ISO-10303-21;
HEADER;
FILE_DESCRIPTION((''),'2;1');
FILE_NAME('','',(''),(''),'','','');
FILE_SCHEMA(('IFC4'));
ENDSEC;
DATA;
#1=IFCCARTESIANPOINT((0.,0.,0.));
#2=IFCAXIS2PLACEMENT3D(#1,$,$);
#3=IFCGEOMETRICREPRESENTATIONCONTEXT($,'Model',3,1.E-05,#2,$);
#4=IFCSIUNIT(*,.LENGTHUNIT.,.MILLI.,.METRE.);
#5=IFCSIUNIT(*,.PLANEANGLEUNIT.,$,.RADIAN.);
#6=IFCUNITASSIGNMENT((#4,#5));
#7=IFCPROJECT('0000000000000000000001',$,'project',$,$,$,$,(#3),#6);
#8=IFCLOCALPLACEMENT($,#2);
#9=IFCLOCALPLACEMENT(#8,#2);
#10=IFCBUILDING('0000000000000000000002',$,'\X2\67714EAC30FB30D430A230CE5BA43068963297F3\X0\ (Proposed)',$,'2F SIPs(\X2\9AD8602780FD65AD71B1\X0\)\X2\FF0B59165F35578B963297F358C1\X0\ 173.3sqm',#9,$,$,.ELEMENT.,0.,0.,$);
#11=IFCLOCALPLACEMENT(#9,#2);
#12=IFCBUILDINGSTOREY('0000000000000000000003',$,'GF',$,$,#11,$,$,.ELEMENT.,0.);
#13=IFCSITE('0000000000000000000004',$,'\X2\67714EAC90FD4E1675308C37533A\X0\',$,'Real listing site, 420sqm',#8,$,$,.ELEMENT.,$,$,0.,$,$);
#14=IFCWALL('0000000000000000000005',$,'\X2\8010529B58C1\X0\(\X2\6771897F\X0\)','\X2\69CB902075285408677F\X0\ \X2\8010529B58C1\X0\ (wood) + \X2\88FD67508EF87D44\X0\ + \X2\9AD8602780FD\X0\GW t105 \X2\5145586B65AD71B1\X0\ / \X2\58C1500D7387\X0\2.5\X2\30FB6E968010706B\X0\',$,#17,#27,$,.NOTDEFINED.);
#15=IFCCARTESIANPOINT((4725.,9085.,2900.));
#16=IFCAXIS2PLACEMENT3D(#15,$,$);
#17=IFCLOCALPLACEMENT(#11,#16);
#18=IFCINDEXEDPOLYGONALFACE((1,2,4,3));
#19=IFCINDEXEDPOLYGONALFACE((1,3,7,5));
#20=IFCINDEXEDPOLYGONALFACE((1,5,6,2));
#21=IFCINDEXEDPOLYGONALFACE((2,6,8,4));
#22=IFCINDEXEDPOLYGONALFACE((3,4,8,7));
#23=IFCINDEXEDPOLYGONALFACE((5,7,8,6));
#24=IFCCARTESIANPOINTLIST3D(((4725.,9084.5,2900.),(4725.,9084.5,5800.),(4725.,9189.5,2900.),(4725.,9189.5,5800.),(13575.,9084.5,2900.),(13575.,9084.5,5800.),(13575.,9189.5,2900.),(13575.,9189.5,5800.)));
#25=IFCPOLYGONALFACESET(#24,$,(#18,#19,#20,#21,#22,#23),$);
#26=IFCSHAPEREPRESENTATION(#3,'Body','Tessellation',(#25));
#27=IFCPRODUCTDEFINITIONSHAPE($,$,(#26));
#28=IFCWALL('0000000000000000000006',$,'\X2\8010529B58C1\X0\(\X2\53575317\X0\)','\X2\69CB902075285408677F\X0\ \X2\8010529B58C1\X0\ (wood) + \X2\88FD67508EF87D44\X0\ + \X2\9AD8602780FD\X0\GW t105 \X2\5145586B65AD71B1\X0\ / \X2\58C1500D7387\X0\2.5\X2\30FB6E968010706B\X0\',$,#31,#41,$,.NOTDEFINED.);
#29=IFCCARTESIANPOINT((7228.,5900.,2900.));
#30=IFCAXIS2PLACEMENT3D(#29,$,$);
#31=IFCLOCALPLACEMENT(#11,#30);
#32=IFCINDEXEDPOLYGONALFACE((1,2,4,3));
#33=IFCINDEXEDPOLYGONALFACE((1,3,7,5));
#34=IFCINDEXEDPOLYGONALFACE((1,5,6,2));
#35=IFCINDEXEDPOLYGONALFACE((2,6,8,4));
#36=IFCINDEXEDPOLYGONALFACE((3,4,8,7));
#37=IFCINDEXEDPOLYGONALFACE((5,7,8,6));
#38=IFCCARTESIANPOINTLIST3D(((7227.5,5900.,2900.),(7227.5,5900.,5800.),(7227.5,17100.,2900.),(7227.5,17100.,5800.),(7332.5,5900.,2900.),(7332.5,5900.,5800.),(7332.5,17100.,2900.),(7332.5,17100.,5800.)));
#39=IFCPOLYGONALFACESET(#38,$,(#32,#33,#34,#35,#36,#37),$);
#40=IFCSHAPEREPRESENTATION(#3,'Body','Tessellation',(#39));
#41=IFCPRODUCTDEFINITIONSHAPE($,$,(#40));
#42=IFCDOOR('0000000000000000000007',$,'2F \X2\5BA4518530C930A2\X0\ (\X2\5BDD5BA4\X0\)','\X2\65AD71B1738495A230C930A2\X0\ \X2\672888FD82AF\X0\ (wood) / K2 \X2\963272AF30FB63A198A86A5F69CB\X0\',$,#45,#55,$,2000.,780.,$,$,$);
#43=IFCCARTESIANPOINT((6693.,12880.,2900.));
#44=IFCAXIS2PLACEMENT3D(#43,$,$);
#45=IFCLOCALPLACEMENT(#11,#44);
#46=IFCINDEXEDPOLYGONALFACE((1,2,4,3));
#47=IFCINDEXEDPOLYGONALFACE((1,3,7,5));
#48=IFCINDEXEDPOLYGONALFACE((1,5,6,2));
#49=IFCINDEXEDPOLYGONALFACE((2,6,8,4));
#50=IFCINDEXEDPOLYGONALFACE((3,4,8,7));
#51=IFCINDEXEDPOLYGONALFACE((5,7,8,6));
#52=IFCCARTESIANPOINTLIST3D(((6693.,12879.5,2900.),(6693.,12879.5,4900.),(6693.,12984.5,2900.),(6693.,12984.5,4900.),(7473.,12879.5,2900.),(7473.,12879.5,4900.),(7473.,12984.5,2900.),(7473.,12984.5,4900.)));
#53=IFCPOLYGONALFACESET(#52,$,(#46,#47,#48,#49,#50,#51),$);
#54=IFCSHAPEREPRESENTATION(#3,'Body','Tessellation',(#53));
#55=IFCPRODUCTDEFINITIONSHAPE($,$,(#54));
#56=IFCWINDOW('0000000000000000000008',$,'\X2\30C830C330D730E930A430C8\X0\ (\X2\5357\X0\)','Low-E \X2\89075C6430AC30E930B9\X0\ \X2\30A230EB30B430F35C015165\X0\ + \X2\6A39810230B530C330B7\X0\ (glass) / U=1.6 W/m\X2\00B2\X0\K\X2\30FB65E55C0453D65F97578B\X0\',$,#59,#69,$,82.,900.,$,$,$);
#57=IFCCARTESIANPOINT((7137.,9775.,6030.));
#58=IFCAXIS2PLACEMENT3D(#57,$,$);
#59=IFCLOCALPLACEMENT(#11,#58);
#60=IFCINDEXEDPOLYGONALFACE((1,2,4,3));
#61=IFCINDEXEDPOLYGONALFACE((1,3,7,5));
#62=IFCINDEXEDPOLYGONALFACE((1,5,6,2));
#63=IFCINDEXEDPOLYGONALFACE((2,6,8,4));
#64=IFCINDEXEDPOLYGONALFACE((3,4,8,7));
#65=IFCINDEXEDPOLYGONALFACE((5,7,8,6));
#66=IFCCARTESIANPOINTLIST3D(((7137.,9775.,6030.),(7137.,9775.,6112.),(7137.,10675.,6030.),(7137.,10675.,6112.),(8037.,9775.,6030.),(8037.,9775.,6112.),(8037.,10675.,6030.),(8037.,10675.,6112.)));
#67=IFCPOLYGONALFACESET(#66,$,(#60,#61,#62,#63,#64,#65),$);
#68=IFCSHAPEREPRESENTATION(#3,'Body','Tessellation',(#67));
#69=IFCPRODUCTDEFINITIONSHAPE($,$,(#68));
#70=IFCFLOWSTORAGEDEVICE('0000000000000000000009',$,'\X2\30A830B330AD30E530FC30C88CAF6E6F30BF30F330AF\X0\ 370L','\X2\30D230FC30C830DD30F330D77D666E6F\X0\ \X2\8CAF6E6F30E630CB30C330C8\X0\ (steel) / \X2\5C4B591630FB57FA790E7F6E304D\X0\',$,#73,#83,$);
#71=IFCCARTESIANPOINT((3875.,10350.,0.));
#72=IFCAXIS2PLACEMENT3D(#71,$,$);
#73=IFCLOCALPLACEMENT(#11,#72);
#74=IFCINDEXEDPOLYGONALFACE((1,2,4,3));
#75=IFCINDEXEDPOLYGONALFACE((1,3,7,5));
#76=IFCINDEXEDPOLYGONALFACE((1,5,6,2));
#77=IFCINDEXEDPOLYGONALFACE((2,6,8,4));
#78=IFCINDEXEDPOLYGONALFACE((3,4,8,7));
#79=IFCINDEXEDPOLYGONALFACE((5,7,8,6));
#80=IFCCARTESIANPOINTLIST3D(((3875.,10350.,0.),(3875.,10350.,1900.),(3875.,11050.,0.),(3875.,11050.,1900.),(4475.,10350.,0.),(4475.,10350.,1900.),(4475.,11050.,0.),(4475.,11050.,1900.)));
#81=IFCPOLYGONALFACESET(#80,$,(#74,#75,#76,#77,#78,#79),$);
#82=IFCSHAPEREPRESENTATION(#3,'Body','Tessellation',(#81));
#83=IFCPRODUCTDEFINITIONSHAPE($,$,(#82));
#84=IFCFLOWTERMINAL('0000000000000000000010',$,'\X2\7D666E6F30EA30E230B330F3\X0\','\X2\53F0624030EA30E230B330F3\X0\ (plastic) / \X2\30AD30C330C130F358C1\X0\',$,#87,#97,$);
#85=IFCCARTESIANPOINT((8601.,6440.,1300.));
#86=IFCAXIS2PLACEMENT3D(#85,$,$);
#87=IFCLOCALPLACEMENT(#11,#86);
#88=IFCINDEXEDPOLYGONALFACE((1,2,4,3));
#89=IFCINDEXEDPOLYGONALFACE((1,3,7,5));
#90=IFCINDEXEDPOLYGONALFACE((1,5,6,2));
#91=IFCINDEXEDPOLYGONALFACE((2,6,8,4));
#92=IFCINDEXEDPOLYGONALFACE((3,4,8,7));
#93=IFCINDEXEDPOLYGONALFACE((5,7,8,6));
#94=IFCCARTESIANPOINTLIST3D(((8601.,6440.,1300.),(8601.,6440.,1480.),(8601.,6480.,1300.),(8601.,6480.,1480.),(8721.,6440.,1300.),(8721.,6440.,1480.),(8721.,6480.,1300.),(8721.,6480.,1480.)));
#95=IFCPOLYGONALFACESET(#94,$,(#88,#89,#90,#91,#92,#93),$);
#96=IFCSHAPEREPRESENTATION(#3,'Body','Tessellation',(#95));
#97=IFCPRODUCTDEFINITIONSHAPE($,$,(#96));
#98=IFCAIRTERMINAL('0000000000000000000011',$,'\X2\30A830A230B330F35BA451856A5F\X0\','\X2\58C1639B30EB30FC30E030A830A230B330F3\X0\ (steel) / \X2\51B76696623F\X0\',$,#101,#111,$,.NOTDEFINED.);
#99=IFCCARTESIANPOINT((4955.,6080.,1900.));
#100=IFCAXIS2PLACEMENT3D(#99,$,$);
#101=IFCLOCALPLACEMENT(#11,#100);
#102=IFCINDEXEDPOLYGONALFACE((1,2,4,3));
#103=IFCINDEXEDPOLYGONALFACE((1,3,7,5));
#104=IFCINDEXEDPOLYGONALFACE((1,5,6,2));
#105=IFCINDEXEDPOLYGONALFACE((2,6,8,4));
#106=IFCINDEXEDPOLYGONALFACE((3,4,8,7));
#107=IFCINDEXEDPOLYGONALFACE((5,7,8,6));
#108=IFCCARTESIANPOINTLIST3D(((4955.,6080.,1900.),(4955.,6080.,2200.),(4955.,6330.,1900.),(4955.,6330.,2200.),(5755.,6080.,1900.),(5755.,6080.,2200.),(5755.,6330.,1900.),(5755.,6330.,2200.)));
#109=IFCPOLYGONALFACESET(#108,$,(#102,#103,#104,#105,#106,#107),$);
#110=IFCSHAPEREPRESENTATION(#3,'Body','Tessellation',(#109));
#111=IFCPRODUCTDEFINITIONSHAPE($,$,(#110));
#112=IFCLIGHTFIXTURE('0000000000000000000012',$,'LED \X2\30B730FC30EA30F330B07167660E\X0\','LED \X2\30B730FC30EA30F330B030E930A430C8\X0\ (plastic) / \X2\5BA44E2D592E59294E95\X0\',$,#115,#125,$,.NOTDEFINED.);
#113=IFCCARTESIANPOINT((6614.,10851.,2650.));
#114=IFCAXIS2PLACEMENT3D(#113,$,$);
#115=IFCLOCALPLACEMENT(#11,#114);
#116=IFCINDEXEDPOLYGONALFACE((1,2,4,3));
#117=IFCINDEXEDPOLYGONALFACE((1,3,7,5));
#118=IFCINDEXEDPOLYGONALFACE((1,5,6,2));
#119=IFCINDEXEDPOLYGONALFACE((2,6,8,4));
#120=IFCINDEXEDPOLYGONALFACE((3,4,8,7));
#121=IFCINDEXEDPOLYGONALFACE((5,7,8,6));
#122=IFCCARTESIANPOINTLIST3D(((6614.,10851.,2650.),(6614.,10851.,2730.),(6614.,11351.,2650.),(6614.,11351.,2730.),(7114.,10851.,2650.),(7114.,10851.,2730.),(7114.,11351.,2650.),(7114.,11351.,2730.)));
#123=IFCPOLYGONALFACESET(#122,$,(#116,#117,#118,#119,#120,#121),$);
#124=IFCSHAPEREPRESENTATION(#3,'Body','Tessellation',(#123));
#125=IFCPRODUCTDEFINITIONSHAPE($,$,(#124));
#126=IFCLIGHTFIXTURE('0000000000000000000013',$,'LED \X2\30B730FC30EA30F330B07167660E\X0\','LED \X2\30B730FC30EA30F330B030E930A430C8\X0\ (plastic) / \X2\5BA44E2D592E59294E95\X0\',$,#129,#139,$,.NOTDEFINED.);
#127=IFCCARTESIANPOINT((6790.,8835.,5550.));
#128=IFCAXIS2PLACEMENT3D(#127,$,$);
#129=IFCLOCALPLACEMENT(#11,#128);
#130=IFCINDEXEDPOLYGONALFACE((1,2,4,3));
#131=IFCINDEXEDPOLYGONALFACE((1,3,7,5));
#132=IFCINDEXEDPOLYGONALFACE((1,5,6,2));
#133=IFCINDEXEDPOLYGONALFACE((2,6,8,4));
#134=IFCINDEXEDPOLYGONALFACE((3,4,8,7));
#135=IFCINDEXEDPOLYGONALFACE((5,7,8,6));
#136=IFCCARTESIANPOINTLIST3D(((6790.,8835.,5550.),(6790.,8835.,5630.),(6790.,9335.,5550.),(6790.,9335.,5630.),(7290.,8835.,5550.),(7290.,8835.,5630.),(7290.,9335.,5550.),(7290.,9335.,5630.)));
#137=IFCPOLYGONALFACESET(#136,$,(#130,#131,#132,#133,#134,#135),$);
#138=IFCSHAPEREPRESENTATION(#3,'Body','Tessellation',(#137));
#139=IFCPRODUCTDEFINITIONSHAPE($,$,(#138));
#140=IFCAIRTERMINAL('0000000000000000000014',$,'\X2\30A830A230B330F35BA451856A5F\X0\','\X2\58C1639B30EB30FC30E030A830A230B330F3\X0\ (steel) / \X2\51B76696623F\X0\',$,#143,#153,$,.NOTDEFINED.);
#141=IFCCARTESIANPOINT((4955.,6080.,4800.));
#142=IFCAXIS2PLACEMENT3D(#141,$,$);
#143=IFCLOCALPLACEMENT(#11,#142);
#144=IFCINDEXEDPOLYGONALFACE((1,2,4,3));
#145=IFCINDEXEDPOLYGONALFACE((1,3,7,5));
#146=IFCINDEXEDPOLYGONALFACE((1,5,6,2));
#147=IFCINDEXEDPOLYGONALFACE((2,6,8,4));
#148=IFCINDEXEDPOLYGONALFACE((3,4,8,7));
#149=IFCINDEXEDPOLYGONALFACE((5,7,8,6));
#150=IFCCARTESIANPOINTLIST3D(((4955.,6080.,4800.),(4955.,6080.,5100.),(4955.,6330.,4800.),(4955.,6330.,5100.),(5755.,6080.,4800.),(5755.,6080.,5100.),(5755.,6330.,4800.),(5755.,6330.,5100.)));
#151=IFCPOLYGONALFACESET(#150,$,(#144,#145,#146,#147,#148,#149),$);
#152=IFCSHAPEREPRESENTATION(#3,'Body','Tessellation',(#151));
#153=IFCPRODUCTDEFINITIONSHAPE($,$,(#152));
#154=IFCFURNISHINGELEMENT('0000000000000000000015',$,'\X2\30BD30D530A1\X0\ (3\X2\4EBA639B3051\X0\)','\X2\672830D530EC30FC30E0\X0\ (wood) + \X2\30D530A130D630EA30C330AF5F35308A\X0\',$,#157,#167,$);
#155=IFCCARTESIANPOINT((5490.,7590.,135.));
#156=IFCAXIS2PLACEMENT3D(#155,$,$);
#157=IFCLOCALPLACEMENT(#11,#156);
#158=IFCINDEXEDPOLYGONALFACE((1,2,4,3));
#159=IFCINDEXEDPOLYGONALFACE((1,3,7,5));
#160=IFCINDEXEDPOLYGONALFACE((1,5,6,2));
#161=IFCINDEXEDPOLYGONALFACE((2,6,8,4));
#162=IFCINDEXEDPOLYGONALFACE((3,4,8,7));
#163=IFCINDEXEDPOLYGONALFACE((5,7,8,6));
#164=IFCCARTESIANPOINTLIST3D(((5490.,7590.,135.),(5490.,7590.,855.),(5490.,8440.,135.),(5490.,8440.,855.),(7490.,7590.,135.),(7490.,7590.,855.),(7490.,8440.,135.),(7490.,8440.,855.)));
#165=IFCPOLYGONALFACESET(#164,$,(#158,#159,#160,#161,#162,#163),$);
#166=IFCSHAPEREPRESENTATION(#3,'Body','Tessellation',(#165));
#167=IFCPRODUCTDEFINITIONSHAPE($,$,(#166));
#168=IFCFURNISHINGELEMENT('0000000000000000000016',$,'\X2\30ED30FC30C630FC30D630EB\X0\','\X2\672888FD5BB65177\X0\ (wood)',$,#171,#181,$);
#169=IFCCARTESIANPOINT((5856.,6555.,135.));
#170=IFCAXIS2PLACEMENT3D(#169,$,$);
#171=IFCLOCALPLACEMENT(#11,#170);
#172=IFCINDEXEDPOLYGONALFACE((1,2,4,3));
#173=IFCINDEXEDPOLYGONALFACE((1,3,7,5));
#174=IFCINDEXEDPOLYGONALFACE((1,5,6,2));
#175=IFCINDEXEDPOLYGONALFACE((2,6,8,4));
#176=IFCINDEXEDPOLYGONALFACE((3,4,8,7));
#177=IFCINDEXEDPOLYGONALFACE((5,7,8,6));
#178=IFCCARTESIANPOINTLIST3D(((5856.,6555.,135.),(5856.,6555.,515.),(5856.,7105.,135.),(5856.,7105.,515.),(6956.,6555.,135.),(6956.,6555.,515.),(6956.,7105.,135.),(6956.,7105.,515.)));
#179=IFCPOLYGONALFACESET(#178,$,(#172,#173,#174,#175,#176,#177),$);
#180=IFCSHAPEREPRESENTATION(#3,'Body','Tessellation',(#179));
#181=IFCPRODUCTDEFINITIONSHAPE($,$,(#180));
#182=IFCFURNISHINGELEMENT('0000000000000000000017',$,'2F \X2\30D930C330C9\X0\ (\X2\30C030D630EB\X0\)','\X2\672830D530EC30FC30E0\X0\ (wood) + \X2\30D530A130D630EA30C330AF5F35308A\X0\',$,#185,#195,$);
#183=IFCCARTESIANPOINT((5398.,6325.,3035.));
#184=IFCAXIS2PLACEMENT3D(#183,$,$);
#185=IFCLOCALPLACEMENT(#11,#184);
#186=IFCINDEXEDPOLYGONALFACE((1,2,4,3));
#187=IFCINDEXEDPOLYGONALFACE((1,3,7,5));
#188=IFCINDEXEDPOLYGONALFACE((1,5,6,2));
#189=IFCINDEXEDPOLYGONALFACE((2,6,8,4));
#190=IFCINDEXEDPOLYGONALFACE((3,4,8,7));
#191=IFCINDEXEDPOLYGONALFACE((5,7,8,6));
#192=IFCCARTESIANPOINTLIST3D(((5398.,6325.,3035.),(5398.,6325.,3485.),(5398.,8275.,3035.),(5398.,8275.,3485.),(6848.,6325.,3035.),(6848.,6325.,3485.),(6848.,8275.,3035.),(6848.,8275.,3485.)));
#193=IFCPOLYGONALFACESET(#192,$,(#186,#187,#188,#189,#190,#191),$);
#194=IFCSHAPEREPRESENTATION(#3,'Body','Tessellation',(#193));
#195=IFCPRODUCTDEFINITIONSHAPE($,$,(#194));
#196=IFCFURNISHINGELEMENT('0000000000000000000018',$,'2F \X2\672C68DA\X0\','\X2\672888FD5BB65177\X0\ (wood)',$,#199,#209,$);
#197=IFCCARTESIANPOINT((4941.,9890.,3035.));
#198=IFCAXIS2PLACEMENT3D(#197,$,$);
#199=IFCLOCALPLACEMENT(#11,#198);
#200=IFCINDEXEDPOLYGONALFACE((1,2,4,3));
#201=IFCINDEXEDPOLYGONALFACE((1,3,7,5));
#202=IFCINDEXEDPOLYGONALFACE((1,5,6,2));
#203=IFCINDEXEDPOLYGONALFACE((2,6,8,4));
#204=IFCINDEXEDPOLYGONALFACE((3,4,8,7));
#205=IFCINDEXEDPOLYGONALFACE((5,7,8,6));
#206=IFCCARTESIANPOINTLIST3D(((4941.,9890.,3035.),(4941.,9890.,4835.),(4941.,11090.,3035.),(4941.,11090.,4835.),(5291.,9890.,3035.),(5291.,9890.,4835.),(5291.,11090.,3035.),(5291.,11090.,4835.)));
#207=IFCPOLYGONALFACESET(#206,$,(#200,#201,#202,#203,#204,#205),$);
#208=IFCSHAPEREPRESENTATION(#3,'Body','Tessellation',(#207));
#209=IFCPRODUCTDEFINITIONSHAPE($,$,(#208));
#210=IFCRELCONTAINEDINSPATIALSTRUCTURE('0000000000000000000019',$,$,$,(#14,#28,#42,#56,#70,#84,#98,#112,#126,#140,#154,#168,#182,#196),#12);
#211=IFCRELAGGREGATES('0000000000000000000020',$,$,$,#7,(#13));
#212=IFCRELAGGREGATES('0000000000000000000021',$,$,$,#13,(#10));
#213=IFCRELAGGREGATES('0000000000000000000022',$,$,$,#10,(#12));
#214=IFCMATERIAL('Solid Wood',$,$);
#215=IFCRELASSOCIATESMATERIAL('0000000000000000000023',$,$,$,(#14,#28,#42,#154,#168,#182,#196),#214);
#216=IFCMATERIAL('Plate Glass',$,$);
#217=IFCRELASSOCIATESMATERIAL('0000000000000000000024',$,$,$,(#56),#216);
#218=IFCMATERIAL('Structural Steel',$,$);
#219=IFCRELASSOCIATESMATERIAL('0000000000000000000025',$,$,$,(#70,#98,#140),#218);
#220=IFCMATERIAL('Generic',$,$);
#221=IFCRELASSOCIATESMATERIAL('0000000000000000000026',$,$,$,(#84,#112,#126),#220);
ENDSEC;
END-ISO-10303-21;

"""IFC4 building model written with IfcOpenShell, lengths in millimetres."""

from ifc_helpers import new_model, si_unit, frame, frame_2d, origin, place, context, project, spatial, rectangle, extrude, material, element, fill, save


model = new_model("IFC4")

# Units and contexts
model_context = context("Model", 3, precision=1e-05, world=origin())
ifc_project = project(units=[si_unit("LENGTHUNIT", "METRE", prefix="MILLI"), si_unit("PLANEANGLEUNIT", "RADIAN")], contexts=[model_context])

# Site, building, storey
site_placement = place(None, origin())
site = spatial("IfcSite", under=ifc_project, at=site_placement, Name="東京都世田谷区", ObjectType="Real listing site, 420sqm", CompositionType="ELEMENT", RefElevation=0.0)
building_placement = place(site_placement, origin())
building = spatial("IfcBuilding", under=site, at=building_placement, Name="東京・ピアノ室と防音 (Proposed)", ObjectType="2F SIPs(高性能断熱)＋外張型防音壁 173.3sqm", CompositionType="ELEMENT", ElevationOfRefHeight=0.0, ElevationOfTerrain=0.0)
storey_placement = place(building_placement, origin())
storey = spatial("IfcBuildingStorey", under=building, at=storey_placement, Name="GF", CompositionType="ELEMENT", Elevation=0.0)

# Shared definitions
ifc_material_1 = material(Name="Solid Wood")

# Wall
wall_1_placement = place(storey_placement, frame((4725.0, 9085.0, 2900.0)))
element("IfcWall", 1, at=wall_1_placement, inside=storey, material=ifc_material_1, Name="耐力壁(東西)", Description="構造用合板 耐力壁 (wood) + 製材軸組 + 高性能GW t105 充填断熱 / 壁倍率2.5・準耐火", PredefinedType="NOTDEFINED", context=model_context, shape_type="SweptSolid", body=[
    extrude(rectangle(XDim=8850.0, YDim=105.0, at=frame_2d((4425.0, 52.0))), frame((4725.0, 9085.0, 2900.0)), (0.0, 0.0, 1.0), 2900.0),
])

# Wall, opening, door
wall_2_placement = place(storey_placement, frame((7228.0, 5900.0, 2900.0)))
wall_2 = element("IfcWall", 2, at=wall_2_placement, inside=storey, material=ifc_material_1, Name="耐力壁(南北)", Description="構造用合板 耐力壁 (wood) + 製材軸組 + 高性能GW t105 充填断熱 / 壁倍率2.5・準耐火", PredefinedType="NOTDEFINED", context=model_context, shape_type="SweptSolid", body=[
    extrude(rectangle(XDim=105.0, YDim=11200.0, at=frame_2d((52.0, 5600.0))), frame((7228.0, 5900.0, 2900.0)), (0.0, 0.0, 1.0), 2900.0),
])
opening_placement = place(storey_placement, frame((6693.0, 12880.0, 2900.0)))
opening = element("IfcOpeningElement", 3, at=opening_placement, cuts=wall_2, PredefinedType="NOTDEFINED", context=model_context, shape_type="SweptSolid", body=[
    extrude(rectangle(XDim=780.0, YDim=105.0, at=frame_2d((390.0, 52.0))), frame((6693.0, 12880.0, 2900.0)), (0.0, 0.0, 1.0), 2000.0),
])
door_placement = place(storey_placement, frame((6693.0, 12880.0, 2900.0)))
door = element("IfcDoor", 4, at=door_placement, inside=storey, material=ifc_material_1, Name="2F 室内ドア (寝室)", Description="断熱玄関ドア 木製芯 (wood) / K2 防犯・採風機構", OverallHeight=2000.0, OverallWidth=780.0, context=model_context, shape_type="SweptSolid", body=[
    extrude(rectangle(XDim=780.0, YDim=105.0, at=frame_2d((390.0, 52.0))), frame((6693.0, 12880.0, 2900.0)), (0.0, 0.0, 1.0), 2000.0),
])
fill(opening, door)

# Window
ifc_material_2 = material(Name="Plate Glass")
window_placement = place(storey_placement, frame((7137.0, 9775.0, 6030.0)))
element("IfcWindow", 5, at=window_placement, inside=storey, material=ifc_material_2, Name="トップライト (南)", Description="Low-E 複層ガラス アルゴン封入 + 樹脂サッシ (glass) / U=1.6 W/m²K・日射取得型", OverallHeight=82.0, OverallWidth=900.0, context=model_context, shape_type="SweptSolid", body=[
    extrude(rectangle(XDim=900.0, YDim=900.0, at=frame_2d((450.0, 450.0))), frame((7137.0, 9775.0, 6030.0)), (0.0, 0.0, 1.0), 82.0),
])

# Flow storage device
ifc_material_3 = material(Name="Structural Steel")
flow_storage_device_placement = place(storey_placement, frame((3875.0, 10350.0, 0.0)))
element("IfcFlowStorageDevice", 6, at=flow_storage_device_placement, inside=storey, material=ifc_material_3, Name="エコキュート貯湯タンク 370L", Description="ヒートポンプ給湯 貯湯ユニット (steel) / 屋外・基礎置き", context=model_context, shape_type="SweptSolid", body=[
    extrude(rectangle(XDim=600.0, YDim=700.0, at=frame_2d((300.0, 350.0))), frame((3875.0, 10350.0, 0.0)), (0.0, 0.0, 1.0), 1900.0),
])

# Flow terminal
ifc_material_4 = material(Name="Generic")
flow_terminal_placement = place(storey_placement, frame((8601.0, 6440.0, 1300.0)))
element("IfcFlowTerminal", 7, at=flow_terminal_placement, inside=storey, material=ifc_material_4, Name="給湯リモコン", Description="台所リモコン (plastic) / キッチン壁", context=model_context, shape_type="SweptSolid", body=[
    extrude(rectangle(XDim=120.0, YDim=40.0, at=frame_2d((60.0, 20.0))), frame((8601.0, 6440.0, 1300.0)), (0.0, 0.0, 1.0), 180.0),
])

# Air terminal
air_terminal_1_placement = place(storey_placement, frame((4955.0, 6080.0, 1900.0)))
element("IfcAirTerminal", 8, at=air_terminal_1_placement, inside=storey, material=ifc_material_3, Name="エアコン室内機", Description="壁掛ルームエアコン (steel) / 冷暖房", PredefinedType="NOTDEFINED", context=model_context, shape_type="SweptSolid", body=[
    extrude(rectangle(XDim=800.0, YDim=250.0, at=frame_2d((400.0, 125.0))), frame((4955.0, 6080.0, 1900.0)), (0.0, 0.0, 1.0), 300.0),
])

# Light fixtures
light_fixture_1_placement = place(storey_placement, frame((6614.0, 10851.0, 2650.0)))
element("IfcLightFixture", 9, at=light_fixture_1_placement, inside=storey, material=ifc_material_4, Name="LED シーリング照明", Description="LED シーリングライト (plastic) / 室中央天井", PredefinedType="NOTDEFINED", context=model_context, shape_type="SweptSolid", body=[
    extrude(rectangle(XDim=500.0, YDim=500.0, at=frame_2d((250.0, 250.0))), frame((6614.0, 10851.0, 2650.0)), (0.0, 0.0, 1.0), 80.0),
])
light_fixture_2_placement = place(storey_placement, frame((6790.0, 8835.0, 5550.0)))
element("IfcLightFixture", 10, at=light_fixture_2_placement, inside=storey, material=ifc_material_4, Name="LED シーリング照明", Description="LED シーリングライト (plastic) / 室中央天井", PredefinedType="NOTDEFINED", context=model_context, shape_type="SweptSolid", body=[
    extrude(rectangle(XDim=500.0, YDim=500.0, at=frame_2d((250.0, 250.0))), frame((6790.0, 8835.0, 5550.0)), (0.0, 0.0, 1.0), 80.0),
])

# Air terminal
air_terminal_2_placement = place(storey_placement, frame((4955.0, 6080.0, 4800.0)))
element("IfcAirTerminal", 11, at=air_terminal_2_placement, inside=storey, material=ifc_material_3, Name="エアコン室内機", Description="壁掛ルームエアコン (steel) / 冷暖房", PredefinedType="NOTDEFINED", context=model_context, shape_type="SweptSolid", body=[
    extrude(rectangle(XDim=800.0, YDim=250.0, at=frame_2d((400.0, 125.0))), frame((4955.0, 6080.0, 4800.0)), (0.0, 0.0, 1.0), 300.0),
])

# Furnishing elements
furnishing_1_placement = place(storey_placement, frame((5490.0, 7590.0, 135.0)))
element("IfcFurnishingElement", 12, at=furnishing_1_placement, inside=storey, material=ifc_material_1, Name="ソファ (3人掛け)", Description="木フレーム (wood) + ファブリック張り", context=model_context, shape_type="SweptSolid", body=[
    extrude(rectangle(XDim=2000.0, YDim=850.0, at=frame_2d((1000.0, 425.0))), frame((5490.0, 7590.0, 135.0)), (0.0, 0.0, 1.0), 720.0),
])
furnishing_2_placement = place(storey_placement, frame((5856.0, 6555.0, 135.0)))
element("IfcFurnishingElement", 13, at=furnishing_2_placement, inside=storey, material=ifc_material_1, Name="ローテーブル", Description="木製家具 (wood)", context=model_context, shape_type="SweptSolid", body=[
    extrude(rectangle(XDim=1100.0, YDim=550.0, at=frame_2d((550.0, 275.0))), frame((5856.0, 6555.0, 135.0)), (0.0, 0.0, 1.0), 380.0),
])
furnishing_3_placement = place(storey_placement, frame((5398.0, 6325.0, 3035.0)))
element("IfcFurnishingElement", 14, at=furnishing_3_placement, inside=storey, material=ifc_material_1, Name="2F ベッド (ダブル)", Description="木フレーム (wood) + ファブリック張り", context=model_context, shape_type="SweptSolid", body=[
    extrude(rectangle(XDim=1450.0, YDim=1950.0, at=frame_2d((725.0, 975.0))), frame((5398.0, 6325.0, 3035.0)), (0.0, 0.0, 1.0), 450.0),
])
furnishing_4_placement = place(storey_placement, frame((4941.0, 9890.0, 3035.0)))
element("IfcFurnishingElement", 15, at=furnishing_4_placement, inside=storey, material=ifc_material_1, Name="2F 本棚", Description="木製家具 (wood)", context=model_context, shape_type="SweptSolid", body=[
    extrude(rectangle(XDim=350.0, YDim=1200.0, at=frame_2d((175.0, 600.0))), frame((4941.0, 9890.0, 3035.0)), (0.0, 0.0, 1.0), 1800.0),
])

save(model, "model.ifc")
